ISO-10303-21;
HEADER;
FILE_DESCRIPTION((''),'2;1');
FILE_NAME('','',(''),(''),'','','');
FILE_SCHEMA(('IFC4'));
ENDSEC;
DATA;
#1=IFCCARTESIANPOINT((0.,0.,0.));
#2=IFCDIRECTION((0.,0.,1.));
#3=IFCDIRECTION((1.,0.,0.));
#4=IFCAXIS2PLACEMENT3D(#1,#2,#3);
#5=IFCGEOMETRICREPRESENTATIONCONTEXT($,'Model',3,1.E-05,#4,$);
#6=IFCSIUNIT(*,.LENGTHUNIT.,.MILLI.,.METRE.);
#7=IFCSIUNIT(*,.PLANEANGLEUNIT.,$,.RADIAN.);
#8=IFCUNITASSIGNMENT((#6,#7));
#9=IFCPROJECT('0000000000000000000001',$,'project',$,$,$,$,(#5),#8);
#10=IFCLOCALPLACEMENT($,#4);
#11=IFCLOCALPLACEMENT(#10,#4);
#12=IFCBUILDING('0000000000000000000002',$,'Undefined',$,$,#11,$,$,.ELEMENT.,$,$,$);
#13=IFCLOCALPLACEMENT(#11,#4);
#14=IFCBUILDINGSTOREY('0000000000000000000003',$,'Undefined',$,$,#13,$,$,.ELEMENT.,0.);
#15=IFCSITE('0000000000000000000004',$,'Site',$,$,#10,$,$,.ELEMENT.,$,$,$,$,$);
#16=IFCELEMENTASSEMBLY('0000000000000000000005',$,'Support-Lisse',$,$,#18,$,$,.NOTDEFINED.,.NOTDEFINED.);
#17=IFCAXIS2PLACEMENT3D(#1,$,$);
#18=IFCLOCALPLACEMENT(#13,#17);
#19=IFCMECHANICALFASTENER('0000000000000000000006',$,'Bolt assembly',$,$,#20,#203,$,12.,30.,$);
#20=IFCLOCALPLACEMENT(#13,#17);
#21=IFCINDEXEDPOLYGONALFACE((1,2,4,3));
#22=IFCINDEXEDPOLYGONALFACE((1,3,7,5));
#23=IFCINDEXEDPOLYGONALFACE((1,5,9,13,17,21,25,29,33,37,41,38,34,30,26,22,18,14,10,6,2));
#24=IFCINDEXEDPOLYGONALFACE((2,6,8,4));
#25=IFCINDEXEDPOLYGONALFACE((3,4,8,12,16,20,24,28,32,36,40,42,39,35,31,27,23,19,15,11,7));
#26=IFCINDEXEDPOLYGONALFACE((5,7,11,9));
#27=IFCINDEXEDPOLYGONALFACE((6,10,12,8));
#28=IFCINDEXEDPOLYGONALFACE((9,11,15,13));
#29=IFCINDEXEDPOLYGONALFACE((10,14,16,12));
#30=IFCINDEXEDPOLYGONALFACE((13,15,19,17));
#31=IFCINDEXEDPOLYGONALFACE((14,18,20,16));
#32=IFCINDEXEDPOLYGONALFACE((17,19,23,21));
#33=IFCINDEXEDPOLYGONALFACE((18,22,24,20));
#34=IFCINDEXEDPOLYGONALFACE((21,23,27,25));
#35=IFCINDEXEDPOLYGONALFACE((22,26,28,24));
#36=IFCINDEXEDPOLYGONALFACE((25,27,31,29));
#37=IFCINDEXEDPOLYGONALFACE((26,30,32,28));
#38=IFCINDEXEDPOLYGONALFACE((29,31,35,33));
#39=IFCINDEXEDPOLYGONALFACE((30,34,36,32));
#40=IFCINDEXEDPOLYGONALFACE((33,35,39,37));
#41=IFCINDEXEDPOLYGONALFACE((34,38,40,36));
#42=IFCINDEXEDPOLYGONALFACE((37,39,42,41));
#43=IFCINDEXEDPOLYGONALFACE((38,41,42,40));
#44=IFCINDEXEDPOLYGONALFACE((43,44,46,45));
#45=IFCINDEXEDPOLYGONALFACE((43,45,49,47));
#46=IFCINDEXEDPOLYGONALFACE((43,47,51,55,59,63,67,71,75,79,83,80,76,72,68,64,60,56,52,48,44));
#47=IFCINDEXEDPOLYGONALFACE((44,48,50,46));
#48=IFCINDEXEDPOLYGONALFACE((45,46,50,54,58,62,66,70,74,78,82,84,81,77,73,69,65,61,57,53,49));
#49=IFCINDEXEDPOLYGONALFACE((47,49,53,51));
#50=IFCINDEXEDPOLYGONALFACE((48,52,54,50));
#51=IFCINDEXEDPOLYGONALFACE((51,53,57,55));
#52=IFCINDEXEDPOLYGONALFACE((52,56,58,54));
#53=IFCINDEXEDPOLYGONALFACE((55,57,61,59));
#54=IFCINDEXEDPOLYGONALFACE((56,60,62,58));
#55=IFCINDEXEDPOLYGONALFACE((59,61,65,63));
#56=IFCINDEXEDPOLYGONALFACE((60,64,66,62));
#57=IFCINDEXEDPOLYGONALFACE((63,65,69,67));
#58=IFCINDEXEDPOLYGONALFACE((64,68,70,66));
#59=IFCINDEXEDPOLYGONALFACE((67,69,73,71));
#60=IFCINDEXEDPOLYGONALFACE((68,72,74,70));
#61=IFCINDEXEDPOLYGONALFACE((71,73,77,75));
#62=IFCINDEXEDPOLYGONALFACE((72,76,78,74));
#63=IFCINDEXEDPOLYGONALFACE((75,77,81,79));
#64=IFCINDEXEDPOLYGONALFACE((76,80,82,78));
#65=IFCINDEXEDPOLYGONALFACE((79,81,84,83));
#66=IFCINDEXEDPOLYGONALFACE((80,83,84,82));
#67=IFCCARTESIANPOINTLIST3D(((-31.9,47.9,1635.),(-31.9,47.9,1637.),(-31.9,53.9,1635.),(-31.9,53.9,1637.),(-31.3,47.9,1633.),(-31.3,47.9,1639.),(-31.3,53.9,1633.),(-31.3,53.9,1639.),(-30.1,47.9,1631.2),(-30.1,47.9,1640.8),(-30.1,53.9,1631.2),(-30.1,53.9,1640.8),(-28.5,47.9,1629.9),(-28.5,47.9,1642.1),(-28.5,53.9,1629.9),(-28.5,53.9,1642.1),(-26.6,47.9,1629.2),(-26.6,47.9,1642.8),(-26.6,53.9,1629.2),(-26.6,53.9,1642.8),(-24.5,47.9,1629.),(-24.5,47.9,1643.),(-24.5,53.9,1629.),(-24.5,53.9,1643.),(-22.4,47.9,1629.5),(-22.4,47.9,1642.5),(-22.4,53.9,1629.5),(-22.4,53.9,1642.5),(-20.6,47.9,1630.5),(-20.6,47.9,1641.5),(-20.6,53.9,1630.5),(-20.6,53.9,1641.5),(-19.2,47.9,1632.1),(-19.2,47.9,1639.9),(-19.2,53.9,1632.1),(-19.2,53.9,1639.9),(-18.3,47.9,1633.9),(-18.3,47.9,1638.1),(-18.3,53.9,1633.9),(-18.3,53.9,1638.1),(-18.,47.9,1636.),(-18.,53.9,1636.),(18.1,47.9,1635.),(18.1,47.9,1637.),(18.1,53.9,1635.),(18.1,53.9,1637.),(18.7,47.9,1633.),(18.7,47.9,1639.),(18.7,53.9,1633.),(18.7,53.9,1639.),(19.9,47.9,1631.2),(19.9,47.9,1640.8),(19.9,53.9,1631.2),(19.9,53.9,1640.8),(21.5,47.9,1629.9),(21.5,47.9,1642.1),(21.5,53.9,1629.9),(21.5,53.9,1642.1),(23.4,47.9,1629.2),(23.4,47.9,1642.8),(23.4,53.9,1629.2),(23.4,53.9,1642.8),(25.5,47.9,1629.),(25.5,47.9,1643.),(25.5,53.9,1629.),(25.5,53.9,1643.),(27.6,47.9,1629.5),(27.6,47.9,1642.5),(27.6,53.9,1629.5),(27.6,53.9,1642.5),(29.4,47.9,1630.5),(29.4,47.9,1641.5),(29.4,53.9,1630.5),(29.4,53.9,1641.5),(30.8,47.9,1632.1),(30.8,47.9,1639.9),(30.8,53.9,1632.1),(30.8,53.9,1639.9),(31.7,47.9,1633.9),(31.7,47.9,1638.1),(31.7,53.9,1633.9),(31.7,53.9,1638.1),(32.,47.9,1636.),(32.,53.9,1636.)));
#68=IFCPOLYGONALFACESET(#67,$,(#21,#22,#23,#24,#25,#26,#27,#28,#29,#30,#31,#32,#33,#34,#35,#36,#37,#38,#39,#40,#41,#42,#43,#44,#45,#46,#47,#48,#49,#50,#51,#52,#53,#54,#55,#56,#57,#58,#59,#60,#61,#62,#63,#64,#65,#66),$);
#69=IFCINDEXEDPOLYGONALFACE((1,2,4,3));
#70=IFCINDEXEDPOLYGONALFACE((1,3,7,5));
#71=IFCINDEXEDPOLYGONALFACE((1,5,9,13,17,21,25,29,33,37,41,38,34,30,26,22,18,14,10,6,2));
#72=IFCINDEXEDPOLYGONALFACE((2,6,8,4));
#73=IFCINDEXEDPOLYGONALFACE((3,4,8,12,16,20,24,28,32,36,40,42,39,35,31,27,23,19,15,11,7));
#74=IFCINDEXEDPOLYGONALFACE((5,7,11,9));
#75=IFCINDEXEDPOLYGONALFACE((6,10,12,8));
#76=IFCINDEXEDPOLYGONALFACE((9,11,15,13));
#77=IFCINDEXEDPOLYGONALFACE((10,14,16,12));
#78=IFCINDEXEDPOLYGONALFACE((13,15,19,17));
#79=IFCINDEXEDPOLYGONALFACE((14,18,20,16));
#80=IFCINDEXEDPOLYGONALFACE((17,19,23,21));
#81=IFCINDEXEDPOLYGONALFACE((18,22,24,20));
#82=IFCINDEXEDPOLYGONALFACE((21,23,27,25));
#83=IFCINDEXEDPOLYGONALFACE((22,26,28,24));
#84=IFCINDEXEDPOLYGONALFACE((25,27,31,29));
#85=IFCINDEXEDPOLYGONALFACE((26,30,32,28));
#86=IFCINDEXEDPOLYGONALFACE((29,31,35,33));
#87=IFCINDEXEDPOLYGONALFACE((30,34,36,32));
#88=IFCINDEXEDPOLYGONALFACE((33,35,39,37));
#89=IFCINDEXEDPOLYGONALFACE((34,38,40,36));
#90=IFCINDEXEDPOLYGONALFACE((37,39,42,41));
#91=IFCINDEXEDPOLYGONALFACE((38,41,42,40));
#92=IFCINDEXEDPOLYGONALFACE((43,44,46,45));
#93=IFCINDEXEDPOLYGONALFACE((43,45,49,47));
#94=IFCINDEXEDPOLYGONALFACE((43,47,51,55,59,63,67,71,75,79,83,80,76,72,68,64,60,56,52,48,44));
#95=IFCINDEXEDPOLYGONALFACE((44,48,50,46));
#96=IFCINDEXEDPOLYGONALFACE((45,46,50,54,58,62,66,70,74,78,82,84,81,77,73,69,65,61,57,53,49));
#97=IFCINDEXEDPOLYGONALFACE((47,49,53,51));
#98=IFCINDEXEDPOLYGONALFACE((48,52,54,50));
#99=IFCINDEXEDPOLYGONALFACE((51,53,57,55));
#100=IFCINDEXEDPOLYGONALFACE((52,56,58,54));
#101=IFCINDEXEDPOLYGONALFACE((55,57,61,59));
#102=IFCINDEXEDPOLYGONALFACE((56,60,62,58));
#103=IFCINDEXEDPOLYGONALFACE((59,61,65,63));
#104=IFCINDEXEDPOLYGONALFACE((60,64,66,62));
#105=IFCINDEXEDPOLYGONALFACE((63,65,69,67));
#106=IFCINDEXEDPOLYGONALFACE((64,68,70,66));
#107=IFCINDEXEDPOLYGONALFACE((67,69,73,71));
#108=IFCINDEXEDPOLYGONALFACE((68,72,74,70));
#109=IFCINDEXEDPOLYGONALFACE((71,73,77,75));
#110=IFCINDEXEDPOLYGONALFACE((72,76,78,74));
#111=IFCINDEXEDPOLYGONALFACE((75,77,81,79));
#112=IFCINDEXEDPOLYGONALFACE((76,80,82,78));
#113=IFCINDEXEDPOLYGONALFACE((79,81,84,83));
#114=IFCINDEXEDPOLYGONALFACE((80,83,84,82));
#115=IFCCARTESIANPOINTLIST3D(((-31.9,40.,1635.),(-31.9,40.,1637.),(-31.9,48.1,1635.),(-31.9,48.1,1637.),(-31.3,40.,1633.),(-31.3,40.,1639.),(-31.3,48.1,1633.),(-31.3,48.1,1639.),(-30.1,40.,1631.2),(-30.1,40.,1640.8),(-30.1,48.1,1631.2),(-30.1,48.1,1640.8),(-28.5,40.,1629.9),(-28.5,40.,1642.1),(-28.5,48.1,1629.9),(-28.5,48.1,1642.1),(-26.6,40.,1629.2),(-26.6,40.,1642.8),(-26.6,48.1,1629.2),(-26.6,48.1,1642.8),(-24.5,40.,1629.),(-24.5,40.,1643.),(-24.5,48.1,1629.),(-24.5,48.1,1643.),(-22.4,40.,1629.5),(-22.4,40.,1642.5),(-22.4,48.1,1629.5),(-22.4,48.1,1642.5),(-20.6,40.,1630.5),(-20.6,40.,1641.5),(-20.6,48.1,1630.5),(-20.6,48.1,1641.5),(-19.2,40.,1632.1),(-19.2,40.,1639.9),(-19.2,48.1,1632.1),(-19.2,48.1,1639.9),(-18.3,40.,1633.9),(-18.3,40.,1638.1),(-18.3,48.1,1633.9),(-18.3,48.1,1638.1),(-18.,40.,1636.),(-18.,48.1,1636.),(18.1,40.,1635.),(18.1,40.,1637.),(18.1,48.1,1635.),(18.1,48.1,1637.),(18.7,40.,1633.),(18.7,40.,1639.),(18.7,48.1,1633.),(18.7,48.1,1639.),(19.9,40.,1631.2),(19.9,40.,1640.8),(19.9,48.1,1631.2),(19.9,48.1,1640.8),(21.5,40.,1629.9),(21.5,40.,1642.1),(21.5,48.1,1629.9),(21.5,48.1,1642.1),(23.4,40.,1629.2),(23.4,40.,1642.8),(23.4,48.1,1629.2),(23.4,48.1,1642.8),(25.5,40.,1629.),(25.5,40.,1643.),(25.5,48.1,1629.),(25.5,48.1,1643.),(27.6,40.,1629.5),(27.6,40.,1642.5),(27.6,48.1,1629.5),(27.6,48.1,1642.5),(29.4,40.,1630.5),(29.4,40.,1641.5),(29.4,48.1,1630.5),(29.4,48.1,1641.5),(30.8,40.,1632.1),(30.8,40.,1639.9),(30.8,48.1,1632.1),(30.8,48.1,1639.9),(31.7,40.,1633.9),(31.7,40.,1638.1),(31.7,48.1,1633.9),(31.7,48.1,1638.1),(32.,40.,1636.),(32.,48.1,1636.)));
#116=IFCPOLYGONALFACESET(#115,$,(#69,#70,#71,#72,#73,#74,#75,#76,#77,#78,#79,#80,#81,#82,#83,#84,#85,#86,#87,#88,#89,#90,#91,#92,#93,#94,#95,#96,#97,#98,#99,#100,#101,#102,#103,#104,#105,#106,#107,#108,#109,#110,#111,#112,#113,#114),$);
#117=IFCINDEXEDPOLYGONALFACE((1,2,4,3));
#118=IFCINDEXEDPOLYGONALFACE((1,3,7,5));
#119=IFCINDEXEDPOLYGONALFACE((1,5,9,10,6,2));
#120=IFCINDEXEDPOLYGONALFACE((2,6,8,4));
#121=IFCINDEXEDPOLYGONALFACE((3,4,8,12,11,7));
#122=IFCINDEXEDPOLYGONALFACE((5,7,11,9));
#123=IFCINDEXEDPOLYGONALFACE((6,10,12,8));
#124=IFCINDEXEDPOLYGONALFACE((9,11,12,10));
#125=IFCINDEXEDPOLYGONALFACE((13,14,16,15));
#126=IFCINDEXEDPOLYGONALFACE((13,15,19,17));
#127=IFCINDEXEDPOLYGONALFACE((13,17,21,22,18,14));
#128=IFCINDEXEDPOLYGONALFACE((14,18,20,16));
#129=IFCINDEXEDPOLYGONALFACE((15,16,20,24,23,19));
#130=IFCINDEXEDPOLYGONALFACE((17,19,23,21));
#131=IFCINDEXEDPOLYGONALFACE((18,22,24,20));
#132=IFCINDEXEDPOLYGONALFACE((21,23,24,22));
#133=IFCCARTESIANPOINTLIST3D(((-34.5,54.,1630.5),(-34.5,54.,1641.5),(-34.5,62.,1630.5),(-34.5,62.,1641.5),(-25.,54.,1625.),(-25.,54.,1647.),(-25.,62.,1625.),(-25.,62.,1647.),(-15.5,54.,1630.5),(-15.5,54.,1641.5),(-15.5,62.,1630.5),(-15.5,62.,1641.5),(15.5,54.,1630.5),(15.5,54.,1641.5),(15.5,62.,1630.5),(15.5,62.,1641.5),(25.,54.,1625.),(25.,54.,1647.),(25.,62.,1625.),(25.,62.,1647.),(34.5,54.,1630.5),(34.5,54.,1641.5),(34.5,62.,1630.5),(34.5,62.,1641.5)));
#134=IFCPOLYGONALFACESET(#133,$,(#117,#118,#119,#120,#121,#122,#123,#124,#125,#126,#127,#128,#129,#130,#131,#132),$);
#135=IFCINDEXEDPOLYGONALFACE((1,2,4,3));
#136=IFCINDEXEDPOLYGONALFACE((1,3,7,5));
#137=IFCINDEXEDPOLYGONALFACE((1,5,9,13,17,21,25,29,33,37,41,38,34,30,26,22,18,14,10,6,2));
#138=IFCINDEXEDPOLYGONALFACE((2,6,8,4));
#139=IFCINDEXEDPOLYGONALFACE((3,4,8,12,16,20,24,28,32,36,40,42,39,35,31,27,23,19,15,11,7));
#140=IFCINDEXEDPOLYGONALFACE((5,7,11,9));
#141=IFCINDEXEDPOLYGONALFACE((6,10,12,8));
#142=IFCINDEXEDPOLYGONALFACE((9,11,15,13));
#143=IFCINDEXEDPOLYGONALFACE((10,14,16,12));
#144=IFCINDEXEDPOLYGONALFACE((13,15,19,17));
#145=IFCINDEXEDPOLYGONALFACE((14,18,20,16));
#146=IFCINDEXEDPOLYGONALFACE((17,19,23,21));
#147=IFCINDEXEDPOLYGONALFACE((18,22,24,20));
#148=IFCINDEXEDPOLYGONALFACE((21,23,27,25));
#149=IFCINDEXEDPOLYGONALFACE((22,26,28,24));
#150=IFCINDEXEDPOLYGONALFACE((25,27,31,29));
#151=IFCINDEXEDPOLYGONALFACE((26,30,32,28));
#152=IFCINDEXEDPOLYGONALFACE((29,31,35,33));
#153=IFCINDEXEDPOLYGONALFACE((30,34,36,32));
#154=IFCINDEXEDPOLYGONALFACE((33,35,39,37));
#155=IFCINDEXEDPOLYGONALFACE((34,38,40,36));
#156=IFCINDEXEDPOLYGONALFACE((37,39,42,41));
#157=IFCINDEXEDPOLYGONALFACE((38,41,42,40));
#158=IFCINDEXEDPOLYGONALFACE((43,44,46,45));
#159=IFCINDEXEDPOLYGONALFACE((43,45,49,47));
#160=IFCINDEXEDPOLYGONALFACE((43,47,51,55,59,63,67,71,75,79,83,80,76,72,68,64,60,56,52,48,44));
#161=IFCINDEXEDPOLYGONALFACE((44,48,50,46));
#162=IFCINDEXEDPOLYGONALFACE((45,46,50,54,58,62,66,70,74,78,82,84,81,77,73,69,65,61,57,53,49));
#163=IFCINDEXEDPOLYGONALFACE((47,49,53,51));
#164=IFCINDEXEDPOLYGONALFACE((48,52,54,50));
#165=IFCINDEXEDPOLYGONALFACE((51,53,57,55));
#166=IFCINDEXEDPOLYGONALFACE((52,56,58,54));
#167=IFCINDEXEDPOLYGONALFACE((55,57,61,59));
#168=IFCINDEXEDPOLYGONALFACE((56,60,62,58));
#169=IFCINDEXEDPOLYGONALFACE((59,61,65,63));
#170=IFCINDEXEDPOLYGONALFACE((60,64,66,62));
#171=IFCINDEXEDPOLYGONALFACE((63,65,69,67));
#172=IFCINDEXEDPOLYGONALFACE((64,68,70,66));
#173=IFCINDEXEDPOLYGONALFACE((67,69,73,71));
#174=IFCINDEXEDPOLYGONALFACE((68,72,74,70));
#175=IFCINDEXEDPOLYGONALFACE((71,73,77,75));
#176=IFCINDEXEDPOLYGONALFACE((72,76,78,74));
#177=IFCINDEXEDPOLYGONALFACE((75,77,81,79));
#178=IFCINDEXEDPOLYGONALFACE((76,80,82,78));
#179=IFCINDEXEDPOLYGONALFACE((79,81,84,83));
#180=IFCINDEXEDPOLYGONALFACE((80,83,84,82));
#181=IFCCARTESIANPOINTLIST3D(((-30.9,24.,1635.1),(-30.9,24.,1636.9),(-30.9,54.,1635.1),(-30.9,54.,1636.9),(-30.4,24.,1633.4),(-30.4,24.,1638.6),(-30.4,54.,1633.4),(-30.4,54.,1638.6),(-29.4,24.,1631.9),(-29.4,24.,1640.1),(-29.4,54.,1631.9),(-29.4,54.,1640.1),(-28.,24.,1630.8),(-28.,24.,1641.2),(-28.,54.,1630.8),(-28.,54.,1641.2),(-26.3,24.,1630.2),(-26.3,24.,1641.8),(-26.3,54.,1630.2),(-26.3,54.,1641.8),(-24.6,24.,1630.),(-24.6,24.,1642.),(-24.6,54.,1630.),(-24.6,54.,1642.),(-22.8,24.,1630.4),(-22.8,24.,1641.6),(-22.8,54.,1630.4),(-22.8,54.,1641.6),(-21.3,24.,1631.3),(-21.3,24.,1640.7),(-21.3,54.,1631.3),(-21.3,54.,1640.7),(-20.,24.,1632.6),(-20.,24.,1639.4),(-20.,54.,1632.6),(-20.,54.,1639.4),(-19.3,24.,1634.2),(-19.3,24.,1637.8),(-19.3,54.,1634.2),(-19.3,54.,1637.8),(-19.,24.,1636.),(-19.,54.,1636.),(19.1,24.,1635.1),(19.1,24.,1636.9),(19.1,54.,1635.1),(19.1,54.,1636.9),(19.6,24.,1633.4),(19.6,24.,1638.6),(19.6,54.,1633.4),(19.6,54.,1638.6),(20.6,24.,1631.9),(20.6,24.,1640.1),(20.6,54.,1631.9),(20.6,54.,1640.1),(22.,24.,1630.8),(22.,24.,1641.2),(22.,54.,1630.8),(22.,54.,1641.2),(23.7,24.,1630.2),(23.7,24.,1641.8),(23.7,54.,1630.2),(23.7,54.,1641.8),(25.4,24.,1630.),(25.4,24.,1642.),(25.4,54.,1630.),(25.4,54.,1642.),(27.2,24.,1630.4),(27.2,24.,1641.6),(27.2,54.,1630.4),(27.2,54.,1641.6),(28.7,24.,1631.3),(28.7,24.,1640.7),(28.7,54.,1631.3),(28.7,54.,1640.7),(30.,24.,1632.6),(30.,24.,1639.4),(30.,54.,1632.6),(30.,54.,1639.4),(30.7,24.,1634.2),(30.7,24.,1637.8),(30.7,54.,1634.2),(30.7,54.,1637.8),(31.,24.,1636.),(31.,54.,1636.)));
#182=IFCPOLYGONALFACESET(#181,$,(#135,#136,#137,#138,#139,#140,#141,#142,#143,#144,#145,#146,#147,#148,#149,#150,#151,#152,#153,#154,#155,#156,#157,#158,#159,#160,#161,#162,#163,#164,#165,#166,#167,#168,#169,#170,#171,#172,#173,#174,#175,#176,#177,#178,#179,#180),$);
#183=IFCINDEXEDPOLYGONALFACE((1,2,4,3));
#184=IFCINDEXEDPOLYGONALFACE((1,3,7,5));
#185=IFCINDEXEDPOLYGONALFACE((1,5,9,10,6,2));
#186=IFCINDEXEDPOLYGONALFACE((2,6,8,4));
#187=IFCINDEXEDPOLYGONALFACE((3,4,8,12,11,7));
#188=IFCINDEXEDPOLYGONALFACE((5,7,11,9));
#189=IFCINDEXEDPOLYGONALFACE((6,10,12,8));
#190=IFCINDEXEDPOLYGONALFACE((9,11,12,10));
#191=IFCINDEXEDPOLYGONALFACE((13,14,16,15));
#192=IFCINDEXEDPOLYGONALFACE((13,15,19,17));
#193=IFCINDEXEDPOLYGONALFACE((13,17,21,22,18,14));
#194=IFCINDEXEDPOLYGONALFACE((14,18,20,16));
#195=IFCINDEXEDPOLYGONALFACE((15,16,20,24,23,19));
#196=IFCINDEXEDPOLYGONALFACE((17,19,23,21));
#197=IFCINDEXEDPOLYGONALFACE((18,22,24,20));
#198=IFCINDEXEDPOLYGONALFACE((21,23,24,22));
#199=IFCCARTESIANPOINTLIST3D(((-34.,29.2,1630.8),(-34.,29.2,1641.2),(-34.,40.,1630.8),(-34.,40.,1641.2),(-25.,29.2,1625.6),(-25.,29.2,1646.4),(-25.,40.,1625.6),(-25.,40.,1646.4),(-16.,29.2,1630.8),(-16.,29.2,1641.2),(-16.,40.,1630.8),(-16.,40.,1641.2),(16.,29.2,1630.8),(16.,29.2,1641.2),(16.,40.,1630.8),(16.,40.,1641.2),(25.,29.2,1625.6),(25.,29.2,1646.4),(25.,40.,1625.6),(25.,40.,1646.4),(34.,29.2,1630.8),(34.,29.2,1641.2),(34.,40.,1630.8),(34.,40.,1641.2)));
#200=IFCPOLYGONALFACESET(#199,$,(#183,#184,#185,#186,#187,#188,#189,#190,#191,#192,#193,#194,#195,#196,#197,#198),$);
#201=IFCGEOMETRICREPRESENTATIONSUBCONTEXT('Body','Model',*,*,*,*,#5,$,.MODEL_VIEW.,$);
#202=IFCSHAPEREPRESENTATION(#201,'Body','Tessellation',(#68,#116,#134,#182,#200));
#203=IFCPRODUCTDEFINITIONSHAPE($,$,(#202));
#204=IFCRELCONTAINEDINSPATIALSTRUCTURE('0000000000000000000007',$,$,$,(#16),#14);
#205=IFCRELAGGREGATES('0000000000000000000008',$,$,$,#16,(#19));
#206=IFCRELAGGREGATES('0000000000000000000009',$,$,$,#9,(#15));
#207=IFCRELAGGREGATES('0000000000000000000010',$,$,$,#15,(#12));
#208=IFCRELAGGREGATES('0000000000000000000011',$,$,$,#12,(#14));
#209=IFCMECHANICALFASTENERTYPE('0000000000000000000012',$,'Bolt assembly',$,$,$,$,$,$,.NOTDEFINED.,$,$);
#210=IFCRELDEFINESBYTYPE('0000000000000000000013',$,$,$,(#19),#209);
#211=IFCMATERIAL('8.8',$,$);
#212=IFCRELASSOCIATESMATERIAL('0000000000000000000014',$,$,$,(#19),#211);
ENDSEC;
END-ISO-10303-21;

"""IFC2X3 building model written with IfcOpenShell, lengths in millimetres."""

from ifc_helpers import new_model, si_unit, frame, origin_with_axes, origin_2d_with_axis, place, context, subcontext, project, spatial, polyline, circle, outline, extrude, source, transform, mapped, material, type_object, element, aggregate, save


model = new_model("IFC2X3")

# Units and contexts
model_context = context("Model", 3, precision=1e-05, world=origin_with_axes())
body_context = subcontext(model_context, "Body", "Model", "MODEL_VIEW")
ifc_project = project(units=[si_unit("LENGTHUNIT", "METRE", prefix="MILLI"), si_unit("PLANEANGLEUNIT", "RADIAN")], contexts=[model_context])

# Site, building, storey
site_placement = place(None, origin_with_axes())
site = spatial("IfcSite", under=ifc_project, at=site_placement, Name="Site", CompositionType="ELEMENT")
building_placement = place(site_placement, origin_with_axes())
building = spatial("IfcBuilding", under=site, at=building_placement, Name="Undefined", CompositionType="ELEMENT")
storey_placement = place(building_placement, origin_with_axes())
storey = spatial("IfcBuildingStorey", under=building, at=storey_placement, Name="Undefined", CompositionType="ELEMENT", Elevation=0.0)

# Shared definitions
mechanical_fastener_type = type_object("IfcMechanicalFastenerType", Name="Bolt assembly")

# Shared definitions
ifc_material_1 = material(Name="8.8")

# Element assembly, mechanical fastener
shared_shape_1 = source(origin_with_axes(), body_context, "Body", "SweptSolid", [
    extrude(circle(Radius=7.0, at=origin_2d_with_axis()), frame((0.0, -5.9, 0.0), z_axis=(0.0, 1.0, 0.0), x_axis=(1.0, 0.0, 0.0)), (0.0, 0.0, 1.0), 6.0),
    extrude(circle(Radius=7.0, at=origin_2d_with_axis()), frame((0.0, -0.1, 0.0), z_axis=(0.0, 1.0, 0.0), x_axis=(1.0, 0.0, 0.0)), (0.0, 0.0, 1.0), 8.1),
    extrude(outline(polyline([(9.5, -5.5), (9.5, 5.5), (0.0, 11.0), (-9.5, 5.5), (-9.5, -5.5), (0.0, -11.0), (9.5, -5.5)])), frame((0.0, -14.0, 0.0), z_axis=(0.0, 1.0, 0.0), x_axis=(1.0, 0.0, 0.0)), (0.0, 0.0, 1.0), 8.0),
    extrude(circle(Radius=6.0, at=origin_2d_with_axis()), frame((0.0, -6.0, 0.0), z_axis=(0.0, 1.0, 0.0), x_axis=(1.0, 0.0, 0.0)), (0.0, 0.0, 1.0), 30.0),
    extrude(outline(polyline([(9.0, -5.2), (9.0, 5.2), (0.0, 10.4), (-9.0, 5.2), (-9.0, -5.2), (0.0, -10.4), (9.0, -5.2)])), frame((0.0, 8.0, 0.0), z_axis=(0.0, 1.0, 0.0), x_axis=(1.0, 0.0, 0.0)), (0.0, 0.0, 1.0), 10.8),
])
assembly_1_placement = place(storey_placement, origin_with_axes())
assembly_1 = element("IfcElementAssembly", 1, at=assembly_1_placement, inside=storey, Name="Support-Lisse", AssemblyPlace="NOTDEFINED", PredefinedType="NOTDEFINED")
mechanical_fastener_1_placement = place(assembly_1_placement, frame((-25.0, 48.0, 1636.0), z_axis=(0.0, 0.0, -1.0), x_axis=(1.0, 0.0, 0.0)))
mechanical_fastener_1 = element("IfcMechanicalFastener", 2, at=mechanical_fastener_1_placement, type_object=mechanical_fastener_type, material=ifc_material_1, Name="Bolt assembly", NominalDiameter=12.0, NominalLength=30.0, context=body_context, shape_type="MappedRepresentation", body=[
    mapped(shared_shape_1, transform((0.0, 0.0, 0.0))),
    mapped(shared_shape_1, transform((50.0, 0.0, 0.0))),
])
aggregate(assembly_1, [mechanical_fastener_1])

save(model, "model.ifc")
